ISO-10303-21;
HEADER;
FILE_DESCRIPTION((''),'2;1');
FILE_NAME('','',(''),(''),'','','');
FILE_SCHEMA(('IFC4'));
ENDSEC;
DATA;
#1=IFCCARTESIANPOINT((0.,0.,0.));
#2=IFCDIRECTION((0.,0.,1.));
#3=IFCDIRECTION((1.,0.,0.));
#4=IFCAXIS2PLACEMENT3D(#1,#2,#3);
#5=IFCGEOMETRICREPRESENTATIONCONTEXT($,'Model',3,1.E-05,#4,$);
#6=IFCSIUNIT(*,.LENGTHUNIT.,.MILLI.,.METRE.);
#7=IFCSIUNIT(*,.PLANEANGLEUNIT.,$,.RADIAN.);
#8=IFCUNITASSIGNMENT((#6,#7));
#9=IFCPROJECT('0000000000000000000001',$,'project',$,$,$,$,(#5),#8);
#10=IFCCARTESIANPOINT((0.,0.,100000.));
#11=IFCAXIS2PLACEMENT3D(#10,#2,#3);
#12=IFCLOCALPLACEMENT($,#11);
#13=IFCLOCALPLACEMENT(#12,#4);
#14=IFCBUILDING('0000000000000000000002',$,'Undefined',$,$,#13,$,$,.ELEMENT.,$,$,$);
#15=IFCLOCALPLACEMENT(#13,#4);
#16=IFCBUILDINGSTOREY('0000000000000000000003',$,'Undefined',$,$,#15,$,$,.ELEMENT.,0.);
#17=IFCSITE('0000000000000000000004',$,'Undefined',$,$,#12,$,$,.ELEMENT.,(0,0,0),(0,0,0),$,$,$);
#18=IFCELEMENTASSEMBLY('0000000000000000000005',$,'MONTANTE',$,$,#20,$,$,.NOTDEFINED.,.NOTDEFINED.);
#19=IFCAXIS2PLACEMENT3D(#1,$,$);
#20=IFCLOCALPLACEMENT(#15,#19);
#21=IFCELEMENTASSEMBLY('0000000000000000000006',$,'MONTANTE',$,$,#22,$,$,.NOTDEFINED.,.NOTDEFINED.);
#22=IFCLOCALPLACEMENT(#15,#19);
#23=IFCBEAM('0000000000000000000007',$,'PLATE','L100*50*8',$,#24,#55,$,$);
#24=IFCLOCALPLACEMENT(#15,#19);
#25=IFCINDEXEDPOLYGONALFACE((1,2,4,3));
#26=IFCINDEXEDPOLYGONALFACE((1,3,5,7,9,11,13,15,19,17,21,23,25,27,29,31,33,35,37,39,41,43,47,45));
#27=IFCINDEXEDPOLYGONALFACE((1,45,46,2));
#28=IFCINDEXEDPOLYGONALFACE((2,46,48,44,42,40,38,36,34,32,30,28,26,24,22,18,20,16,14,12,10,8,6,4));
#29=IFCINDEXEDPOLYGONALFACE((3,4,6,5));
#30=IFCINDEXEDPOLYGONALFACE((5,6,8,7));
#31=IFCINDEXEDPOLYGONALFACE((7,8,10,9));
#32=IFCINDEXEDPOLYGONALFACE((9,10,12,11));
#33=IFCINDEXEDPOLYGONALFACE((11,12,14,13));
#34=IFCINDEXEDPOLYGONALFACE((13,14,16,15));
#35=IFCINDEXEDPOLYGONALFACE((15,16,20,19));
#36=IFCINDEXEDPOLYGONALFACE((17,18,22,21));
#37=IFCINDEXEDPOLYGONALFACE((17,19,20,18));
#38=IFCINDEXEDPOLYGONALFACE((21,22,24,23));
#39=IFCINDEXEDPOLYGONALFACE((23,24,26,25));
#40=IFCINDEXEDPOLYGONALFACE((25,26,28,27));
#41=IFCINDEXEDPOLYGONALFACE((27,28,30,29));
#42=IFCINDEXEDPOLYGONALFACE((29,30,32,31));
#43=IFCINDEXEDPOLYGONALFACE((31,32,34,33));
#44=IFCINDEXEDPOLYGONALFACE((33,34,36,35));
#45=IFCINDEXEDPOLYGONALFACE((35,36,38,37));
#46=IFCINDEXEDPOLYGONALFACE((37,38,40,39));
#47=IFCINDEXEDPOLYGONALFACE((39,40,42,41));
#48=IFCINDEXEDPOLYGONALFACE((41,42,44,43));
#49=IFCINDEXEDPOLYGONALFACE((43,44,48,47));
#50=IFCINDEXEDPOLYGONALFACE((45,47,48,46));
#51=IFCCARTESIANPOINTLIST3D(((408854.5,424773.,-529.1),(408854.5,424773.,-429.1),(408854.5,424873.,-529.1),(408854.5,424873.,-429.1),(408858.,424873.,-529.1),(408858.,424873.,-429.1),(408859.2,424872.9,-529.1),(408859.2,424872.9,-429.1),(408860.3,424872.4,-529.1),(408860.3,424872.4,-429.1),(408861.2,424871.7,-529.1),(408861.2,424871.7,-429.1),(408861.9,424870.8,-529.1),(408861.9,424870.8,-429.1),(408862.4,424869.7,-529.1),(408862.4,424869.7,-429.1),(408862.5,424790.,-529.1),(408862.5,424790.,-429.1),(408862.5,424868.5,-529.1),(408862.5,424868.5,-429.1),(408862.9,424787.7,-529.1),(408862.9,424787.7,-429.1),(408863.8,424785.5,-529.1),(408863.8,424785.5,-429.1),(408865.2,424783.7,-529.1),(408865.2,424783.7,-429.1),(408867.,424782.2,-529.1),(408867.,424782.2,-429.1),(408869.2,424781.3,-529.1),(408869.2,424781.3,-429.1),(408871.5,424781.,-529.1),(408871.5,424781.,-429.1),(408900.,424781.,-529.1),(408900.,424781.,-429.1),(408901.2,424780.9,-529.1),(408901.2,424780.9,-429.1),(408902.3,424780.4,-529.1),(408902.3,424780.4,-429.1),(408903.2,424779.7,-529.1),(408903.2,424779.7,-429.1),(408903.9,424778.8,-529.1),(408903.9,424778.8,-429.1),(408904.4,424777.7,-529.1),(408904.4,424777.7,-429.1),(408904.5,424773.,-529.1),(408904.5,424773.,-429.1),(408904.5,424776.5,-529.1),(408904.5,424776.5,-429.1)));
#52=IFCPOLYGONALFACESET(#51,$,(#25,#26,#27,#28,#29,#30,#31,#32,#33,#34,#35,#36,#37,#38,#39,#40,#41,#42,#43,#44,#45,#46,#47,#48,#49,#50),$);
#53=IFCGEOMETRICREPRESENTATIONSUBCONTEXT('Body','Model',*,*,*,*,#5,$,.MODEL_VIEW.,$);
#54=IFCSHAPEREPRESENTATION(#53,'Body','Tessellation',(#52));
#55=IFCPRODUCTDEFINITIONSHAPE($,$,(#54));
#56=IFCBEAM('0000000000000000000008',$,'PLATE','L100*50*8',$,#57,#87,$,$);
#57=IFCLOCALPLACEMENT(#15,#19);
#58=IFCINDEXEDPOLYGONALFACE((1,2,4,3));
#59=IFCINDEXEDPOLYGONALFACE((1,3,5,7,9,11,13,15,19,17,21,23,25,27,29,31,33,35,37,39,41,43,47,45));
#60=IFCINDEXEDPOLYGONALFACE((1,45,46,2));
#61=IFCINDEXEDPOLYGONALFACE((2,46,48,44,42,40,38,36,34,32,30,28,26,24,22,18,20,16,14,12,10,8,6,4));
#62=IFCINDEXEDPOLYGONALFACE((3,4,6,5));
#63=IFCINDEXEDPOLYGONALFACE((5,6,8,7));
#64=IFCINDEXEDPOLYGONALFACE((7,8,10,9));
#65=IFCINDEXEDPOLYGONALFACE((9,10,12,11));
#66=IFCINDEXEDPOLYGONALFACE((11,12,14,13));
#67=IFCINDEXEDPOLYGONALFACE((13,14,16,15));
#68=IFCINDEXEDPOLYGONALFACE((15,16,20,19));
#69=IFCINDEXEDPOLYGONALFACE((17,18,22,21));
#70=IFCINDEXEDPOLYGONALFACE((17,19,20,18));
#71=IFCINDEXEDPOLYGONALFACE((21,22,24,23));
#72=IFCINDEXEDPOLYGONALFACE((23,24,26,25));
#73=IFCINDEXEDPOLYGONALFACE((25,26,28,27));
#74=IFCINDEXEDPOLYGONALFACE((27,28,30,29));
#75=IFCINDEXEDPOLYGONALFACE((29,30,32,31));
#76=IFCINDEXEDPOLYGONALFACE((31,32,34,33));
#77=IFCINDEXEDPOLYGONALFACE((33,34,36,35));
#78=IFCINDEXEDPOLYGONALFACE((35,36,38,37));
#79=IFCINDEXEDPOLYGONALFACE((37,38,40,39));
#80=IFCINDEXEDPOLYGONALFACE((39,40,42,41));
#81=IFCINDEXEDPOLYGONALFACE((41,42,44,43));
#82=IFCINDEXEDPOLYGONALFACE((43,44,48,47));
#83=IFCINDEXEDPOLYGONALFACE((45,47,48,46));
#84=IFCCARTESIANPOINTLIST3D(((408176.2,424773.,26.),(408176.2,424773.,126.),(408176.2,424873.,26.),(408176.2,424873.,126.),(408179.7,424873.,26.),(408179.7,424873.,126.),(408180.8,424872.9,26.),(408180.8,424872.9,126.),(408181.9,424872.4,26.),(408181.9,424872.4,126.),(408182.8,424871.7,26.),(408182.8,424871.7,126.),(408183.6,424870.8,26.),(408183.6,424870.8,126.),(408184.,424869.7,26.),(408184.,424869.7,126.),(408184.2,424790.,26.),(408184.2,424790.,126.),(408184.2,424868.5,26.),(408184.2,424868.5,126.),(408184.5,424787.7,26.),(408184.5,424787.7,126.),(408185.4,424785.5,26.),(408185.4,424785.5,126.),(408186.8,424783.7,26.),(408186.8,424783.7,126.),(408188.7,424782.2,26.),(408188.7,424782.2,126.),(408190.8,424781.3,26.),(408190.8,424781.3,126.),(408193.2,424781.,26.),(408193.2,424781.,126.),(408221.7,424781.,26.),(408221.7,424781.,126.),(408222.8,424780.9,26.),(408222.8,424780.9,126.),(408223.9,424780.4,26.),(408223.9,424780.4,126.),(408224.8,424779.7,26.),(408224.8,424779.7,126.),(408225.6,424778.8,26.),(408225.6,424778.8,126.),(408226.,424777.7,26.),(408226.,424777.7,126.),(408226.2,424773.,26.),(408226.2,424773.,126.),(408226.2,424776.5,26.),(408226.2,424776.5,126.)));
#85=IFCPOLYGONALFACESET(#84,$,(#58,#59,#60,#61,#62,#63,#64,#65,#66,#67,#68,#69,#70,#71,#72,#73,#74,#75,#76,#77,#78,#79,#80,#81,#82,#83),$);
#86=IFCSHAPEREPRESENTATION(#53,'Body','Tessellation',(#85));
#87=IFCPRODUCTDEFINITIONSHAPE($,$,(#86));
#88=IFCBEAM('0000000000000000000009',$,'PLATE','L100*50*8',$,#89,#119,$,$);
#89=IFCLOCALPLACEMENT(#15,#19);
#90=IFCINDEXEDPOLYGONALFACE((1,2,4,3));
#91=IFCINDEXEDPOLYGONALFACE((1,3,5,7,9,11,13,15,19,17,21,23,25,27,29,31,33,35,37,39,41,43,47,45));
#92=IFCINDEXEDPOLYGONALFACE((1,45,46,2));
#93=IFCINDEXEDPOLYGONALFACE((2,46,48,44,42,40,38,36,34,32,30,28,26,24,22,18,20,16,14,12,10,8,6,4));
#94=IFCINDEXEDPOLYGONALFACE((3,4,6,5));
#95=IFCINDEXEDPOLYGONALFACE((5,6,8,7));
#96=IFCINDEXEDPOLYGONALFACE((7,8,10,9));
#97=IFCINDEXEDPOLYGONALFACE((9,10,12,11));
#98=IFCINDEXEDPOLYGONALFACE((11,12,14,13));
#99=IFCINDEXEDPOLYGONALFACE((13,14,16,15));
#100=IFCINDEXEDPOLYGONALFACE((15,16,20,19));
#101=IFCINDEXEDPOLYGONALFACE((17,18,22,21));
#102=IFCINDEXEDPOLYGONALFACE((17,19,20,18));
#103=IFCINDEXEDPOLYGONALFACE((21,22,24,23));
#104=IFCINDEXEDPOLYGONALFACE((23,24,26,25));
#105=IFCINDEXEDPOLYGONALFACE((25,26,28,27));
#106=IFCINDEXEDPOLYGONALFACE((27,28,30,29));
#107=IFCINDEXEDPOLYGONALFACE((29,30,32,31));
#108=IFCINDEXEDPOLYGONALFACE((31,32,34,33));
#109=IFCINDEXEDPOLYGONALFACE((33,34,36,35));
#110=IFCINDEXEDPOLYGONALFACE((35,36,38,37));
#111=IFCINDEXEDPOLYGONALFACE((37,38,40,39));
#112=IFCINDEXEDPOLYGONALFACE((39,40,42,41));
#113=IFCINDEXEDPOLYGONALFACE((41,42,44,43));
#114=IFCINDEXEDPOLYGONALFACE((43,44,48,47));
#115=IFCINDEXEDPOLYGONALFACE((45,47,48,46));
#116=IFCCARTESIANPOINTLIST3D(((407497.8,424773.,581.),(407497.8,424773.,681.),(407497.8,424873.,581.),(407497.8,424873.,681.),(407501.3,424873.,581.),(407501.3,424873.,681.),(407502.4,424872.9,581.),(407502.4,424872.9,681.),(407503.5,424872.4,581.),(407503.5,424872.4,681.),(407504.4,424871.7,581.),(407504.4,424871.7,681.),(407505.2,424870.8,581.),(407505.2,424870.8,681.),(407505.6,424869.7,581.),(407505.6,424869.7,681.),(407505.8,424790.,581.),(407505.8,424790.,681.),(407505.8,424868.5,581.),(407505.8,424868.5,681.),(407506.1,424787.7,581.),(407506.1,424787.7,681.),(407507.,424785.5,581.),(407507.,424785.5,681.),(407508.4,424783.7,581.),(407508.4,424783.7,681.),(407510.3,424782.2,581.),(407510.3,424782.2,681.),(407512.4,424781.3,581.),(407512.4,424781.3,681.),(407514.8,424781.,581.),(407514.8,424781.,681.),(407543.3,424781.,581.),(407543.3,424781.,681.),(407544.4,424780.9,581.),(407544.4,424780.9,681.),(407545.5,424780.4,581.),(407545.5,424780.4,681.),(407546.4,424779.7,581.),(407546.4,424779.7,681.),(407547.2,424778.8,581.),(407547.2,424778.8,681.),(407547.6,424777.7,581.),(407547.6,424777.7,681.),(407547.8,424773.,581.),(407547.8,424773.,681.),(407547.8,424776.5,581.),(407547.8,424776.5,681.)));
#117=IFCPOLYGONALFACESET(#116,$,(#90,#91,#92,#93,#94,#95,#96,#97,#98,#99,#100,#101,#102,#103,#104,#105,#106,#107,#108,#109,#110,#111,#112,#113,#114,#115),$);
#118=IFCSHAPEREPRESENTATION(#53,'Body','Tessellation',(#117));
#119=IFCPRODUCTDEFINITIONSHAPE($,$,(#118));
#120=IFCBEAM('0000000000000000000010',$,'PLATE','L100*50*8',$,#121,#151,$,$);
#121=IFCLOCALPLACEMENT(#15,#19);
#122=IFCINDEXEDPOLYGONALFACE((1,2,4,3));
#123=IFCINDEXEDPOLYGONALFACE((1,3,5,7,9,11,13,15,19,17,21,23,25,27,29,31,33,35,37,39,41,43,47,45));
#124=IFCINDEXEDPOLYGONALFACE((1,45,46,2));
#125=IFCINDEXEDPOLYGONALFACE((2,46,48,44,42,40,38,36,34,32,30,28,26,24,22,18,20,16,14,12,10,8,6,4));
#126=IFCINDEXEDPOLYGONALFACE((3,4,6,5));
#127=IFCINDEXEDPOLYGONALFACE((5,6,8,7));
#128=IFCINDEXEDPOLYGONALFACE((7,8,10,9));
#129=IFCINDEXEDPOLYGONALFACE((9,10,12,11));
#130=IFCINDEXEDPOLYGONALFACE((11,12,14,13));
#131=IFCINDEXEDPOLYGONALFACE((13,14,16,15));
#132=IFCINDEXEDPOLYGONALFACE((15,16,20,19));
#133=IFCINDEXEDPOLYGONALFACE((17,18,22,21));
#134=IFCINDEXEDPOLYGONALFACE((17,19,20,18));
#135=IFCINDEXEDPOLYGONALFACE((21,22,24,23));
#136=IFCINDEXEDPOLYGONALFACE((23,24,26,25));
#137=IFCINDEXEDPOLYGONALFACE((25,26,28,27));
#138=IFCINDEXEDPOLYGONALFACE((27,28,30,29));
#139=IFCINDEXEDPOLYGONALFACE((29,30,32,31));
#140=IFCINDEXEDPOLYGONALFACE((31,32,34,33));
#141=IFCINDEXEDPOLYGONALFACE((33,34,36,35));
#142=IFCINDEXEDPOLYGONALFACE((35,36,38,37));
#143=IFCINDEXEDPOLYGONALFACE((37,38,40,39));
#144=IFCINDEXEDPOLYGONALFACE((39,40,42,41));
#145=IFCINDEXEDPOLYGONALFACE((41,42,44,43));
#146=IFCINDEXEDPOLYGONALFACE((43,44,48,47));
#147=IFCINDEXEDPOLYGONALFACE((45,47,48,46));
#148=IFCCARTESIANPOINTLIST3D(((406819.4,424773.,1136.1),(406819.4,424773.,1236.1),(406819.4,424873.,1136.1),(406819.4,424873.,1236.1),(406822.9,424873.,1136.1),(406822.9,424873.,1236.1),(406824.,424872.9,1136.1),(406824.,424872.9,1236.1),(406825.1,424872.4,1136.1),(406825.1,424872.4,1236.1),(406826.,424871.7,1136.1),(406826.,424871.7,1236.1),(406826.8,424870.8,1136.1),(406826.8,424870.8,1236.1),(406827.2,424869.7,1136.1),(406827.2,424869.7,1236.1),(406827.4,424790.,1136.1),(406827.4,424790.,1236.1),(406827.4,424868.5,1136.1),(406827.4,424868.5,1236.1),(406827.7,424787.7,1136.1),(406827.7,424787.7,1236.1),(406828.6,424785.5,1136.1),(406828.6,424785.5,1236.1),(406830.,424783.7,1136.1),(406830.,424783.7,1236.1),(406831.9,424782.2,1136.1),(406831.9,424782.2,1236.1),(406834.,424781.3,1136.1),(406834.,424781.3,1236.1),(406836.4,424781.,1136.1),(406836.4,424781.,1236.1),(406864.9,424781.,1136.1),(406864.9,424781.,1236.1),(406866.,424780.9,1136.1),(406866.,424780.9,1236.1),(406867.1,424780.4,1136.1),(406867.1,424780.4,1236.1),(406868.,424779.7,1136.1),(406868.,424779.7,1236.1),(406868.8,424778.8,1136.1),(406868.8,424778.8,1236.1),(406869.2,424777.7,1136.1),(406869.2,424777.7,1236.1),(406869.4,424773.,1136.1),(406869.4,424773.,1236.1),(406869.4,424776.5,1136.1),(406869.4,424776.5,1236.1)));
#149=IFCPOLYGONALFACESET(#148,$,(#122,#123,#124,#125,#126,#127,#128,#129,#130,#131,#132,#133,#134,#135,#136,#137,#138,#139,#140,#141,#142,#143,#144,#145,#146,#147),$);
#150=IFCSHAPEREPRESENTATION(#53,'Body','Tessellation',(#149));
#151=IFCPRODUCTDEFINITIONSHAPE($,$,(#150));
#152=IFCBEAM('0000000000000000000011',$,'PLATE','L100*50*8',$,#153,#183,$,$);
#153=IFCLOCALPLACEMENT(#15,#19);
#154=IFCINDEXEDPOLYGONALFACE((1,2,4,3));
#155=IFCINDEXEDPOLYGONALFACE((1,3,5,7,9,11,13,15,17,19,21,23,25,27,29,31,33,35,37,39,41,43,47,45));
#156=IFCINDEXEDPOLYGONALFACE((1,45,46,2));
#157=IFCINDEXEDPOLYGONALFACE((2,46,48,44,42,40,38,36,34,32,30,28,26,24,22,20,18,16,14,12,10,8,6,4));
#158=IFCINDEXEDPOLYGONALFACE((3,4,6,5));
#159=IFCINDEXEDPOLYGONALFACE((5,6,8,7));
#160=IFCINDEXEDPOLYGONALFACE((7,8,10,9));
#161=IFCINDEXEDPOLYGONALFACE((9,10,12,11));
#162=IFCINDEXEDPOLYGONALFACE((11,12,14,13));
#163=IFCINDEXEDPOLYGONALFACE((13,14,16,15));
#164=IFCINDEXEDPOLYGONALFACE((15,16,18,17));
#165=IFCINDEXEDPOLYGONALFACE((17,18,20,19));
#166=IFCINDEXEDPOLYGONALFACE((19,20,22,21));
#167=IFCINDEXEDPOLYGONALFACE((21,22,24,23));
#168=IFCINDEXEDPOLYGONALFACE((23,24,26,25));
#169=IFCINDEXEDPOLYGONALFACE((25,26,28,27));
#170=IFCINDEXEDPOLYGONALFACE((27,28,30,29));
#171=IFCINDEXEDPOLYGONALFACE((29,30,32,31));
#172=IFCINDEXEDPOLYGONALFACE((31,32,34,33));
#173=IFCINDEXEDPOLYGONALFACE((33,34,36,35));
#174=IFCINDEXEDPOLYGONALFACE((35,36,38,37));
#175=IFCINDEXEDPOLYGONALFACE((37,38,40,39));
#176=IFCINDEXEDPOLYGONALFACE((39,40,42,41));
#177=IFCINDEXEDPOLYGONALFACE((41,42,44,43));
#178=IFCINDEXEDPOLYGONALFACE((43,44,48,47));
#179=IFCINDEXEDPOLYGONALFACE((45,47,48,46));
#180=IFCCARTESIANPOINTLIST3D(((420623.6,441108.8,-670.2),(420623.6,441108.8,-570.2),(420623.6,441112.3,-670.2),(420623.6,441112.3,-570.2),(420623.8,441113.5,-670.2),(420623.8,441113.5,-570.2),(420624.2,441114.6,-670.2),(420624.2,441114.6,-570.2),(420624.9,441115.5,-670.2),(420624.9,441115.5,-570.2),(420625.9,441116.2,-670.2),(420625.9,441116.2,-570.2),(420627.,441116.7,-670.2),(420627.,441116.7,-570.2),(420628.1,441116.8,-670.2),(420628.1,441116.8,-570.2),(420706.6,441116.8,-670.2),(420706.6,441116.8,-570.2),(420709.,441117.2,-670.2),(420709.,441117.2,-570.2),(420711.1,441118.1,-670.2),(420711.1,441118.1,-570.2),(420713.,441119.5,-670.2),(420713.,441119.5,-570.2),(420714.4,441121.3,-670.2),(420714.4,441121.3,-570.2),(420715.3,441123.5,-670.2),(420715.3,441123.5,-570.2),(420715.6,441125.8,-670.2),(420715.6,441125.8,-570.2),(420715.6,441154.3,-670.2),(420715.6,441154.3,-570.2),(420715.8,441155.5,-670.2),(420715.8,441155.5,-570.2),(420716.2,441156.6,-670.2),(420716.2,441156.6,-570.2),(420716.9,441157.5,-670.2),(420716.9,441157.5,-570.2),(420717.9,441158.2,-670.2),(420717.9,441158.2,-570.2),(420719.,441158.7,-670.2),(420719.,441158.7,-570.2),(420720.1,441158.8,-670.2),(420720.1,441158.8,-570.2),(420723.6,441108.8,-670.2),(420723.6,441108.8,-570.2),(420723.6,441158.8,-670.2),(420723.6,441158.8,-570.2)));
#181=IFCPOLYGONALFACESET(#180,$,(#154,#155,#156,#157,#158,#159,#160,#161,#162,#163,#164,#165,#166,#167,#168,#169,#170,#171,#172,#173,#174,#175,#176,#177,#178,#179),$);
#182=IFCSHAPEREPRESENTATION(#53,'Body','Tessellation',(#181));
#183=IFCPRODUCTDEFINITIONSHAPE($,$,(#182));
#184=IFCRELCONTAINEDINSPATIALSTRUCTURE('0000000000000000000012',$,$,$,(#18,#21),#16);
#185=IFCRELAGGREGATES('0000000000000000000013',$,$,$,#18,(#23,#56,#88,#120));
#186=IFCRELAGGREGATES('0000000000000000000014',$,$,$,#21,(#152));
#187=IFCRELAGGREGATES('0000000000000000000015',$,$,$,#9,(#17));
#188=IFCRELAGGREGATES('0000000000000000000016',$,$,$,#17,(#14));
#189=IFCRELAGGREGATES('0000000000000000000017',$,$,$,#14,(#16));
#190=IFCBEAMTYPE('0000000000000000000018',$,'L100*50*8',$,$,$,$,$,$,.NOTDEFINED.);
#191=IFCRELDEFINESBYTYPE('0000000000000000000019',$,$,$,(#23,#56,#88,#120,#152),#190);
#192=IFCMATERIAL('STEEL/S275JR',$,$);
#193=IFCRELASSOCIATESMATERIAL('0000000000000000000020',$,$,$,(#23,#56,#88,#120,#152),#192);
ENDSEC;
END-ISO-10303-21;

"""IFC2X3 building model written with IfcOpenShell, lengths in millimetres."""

from ifc_helpers import new_model, si_unit, frame, origin_with_axes, origin_2d_with_axis, place, context, subcontext, project, spatial, l_section, extrude, material, type_object, element, aggregate, save


model = new_model("IFC2X3")

# Units and contexts
model_context = context("Model", 3, precision=1e-05, world=origin_with_axes())
body_context = subcontext(model_context, "Body", "Model", "MODEL_VIEW")
ifc_project = project(units=[si_unit("LENGTHUNIT", "METRE", prefix="MILLI"), si_unit("PLANEANGLEUNIT", "RADIAN")], contexts=[model_context])

# Site, building, storey
site_placement = place(None, frame((0.0, 0.0, 100000.0), z_axis=(0.0, 0.0, 1.0), x_axis=(1.0, 0.0, 0.0)))
site = spatial("IfcSite", under=ifc_project, at=site_placement, Name="Undefined", CompositionType="ELEMENT", RefLatitude=(0, 0, 0), RefLongitude=(0, 0, 0))
building_placement = place(site_placement, origin_with_axes())
building = spatial("IfcBuilding", under=site, at=building_placement, Name="Undefined", CompositionType="ELEMENT")
storey_placement = place(building_placement, origin_with_axes())
storey = spatial("IfcBuildingStorey", under=building, at=storey_placement, Name="Undefined", CompositionType="ELEMENT", Elevation=0.0)

# Element assembly
assembly_1_placement = place(storey_placement, origin_with_axes())
assembly_1 = element("IfcElementAssembly", 1, at=assembly_1_placement, inside=storey, Name="MONTANTE", AssemblyPlace="NOTDEFINED", PredefinedType="NOTDEFINED")

# Element assembly
assembly_2_placement = place(storey_placement, origin_with_axes())
assembly_2 = element("IfcElementAssembly", 2, at=assembly_2_placement, inside=storey, Name="MONTANTE", AssemblyPlace="NOTDEFINED", PredefinedType="NOTDEFINED")
ifc_material_1 = material(Name="STEEL/S275JR")

# Beams
beam_type_1 = type_object("IfcBeamType", Name="L100*50*8", PredefinedType="NOTDEFINED")
beam_1_placement = place(assembly_1_placement, frame((408879.5, 424823.0, -429.1), z_axis=(0.0, 1.0, 0.0), x_axis=(0.0, 0.0, -1.0)))
beam_1 = element("IfcBeam", 3, at=beam_1_placement, type_object=beam_type_1, material=ifc_material_1, Name="PLATE", Description="L100*50*8", context=body_context, shape_type="SweptSolid", body=[
    extrude(l_section(Depth=100.0, Width=50.0, Thickness=8.0, FilletRadius=9.0, EdgeRadius=4.5, at=origin_2d_with_axis()), frame((100.0, 0.0, 0.0), z_axis=(-1.0, 0.0, 0.0), x_axis=(0.0, -1.0, 0.0)), (0.0, 0.0, 1.0), 100.0),
])
beam_2_placement = place(assembly_1_placement, frame((408201.2, 424823.0, 126.0), z_axis=(0.0, 1.0, 0.0), x_axis=(0.0, 0.0, -1.0)))
beam_2 = element("IfcBeam", 4, at=beam_2_placement, type_object=beam_type_1, material=ifc_material_1, Name="PLATE", Description="L100*50*8", context=body_context, shape_type="SweptSolid", body=[
    extrude(l_section(Depth=100.0, Width=50.0, Thickness=8.0, FilletRadius=9.0, EdgeRadius=4.5, at=origin_2d_with_axis()), frame((100.0, 0.0, 0.0), z_axis=(-1.0, 0.0, 0.0), x_axis=(0.0, -1.0, 0.0)), (0.0, 0.0, 1.0), 100.0),
])
beam_3_placement = place(assembly_1_placement, frame((407522.8, 424823.0, 681.0), z_axis=(0.0, 1.0, 0.0), x_axis=(0.0, 0.0, -1.0)))
beam_3 = element("IfcBeam", 5, at=beam_3_placement, type_object=beam_type_1, material=ifc_material_1, Name="PLATE", Description="L100*50*8", context=body_context, shape_type="SweptSolid", body=[
    extrude(l_section(Depth=100.0, Width=50.0, Thickness=8.0, FilletRadius=9.0, EdgeRadius=4.5, at=origin_2d_with_axis()), frame((100.0, 0.0, 0.0), z_axis=(-1.0, 0.0, 0.0), x_axis=(0.0, -1.0, 0.0)), (0.0, 0.0, 1.0), 100.0),
])
beam_4_placement = place(assembly_1_placement, frame((406844.4, 424823.0, 1236.1), z_axis=(0.0, 1.0, 0.0), x_axis=(0.0, 0.0, -1.0)))
beam_4 = element("IfcBeam", 6, at=beam_4_placement, type_object=beam_type_1, material=ifc_material_1, Name="PLATE", Description="L100*50*8", context=body_context, shape_type="SweptSolid", body=[
    extrude(l_section(Depth=100.0, Width=50.0, Thickness=8.0, FilletRadius=9.0, EdgeRadius=4.5, at=origin_2d_with_axis()), frame((100.0, 0.0, 0.0), z_axis=(-1.0, 0.0, 0.0), x_axis=(0.0, -1.0, 0.0)), (0.0, 0.0, 1.0), 100.0),
])
beam_5_placement = place(assembly_2_placement, frame((420673.6, 441133.8, -570.2), z_axis=(-1.0, 0.000001, 0.0), x_axis=(0.0, 0.0, -1.0)))
beam_5 = element("IfcBeam", 7, at=beam_5_placement, type_object=beam_type_1, material=ifc_material_1, Name="PLATE", Description="L100*50*8", context=body_context, shape_type="SweptSolid", body=[
    extrude(l_section(Depth=100.0, Width=50.0, Thickness=8.0, FilletRadius=9.0, EdgeRadius=4.5, at=origin_2d_with_axis()), frame((100.0, 0.0, 0.0), z_axis=(-1.0, 0.0, 0.0), x_axis=(0.0, -1.0, 0.0)), (0.0, 0.0, 1.0), 100.0),
])

aggregate(assembly_1, [beam_1, beam_2, beam_3, beam_4])

aggregate(assembly_2, [beam_5])

save(model, "model.ifc")
